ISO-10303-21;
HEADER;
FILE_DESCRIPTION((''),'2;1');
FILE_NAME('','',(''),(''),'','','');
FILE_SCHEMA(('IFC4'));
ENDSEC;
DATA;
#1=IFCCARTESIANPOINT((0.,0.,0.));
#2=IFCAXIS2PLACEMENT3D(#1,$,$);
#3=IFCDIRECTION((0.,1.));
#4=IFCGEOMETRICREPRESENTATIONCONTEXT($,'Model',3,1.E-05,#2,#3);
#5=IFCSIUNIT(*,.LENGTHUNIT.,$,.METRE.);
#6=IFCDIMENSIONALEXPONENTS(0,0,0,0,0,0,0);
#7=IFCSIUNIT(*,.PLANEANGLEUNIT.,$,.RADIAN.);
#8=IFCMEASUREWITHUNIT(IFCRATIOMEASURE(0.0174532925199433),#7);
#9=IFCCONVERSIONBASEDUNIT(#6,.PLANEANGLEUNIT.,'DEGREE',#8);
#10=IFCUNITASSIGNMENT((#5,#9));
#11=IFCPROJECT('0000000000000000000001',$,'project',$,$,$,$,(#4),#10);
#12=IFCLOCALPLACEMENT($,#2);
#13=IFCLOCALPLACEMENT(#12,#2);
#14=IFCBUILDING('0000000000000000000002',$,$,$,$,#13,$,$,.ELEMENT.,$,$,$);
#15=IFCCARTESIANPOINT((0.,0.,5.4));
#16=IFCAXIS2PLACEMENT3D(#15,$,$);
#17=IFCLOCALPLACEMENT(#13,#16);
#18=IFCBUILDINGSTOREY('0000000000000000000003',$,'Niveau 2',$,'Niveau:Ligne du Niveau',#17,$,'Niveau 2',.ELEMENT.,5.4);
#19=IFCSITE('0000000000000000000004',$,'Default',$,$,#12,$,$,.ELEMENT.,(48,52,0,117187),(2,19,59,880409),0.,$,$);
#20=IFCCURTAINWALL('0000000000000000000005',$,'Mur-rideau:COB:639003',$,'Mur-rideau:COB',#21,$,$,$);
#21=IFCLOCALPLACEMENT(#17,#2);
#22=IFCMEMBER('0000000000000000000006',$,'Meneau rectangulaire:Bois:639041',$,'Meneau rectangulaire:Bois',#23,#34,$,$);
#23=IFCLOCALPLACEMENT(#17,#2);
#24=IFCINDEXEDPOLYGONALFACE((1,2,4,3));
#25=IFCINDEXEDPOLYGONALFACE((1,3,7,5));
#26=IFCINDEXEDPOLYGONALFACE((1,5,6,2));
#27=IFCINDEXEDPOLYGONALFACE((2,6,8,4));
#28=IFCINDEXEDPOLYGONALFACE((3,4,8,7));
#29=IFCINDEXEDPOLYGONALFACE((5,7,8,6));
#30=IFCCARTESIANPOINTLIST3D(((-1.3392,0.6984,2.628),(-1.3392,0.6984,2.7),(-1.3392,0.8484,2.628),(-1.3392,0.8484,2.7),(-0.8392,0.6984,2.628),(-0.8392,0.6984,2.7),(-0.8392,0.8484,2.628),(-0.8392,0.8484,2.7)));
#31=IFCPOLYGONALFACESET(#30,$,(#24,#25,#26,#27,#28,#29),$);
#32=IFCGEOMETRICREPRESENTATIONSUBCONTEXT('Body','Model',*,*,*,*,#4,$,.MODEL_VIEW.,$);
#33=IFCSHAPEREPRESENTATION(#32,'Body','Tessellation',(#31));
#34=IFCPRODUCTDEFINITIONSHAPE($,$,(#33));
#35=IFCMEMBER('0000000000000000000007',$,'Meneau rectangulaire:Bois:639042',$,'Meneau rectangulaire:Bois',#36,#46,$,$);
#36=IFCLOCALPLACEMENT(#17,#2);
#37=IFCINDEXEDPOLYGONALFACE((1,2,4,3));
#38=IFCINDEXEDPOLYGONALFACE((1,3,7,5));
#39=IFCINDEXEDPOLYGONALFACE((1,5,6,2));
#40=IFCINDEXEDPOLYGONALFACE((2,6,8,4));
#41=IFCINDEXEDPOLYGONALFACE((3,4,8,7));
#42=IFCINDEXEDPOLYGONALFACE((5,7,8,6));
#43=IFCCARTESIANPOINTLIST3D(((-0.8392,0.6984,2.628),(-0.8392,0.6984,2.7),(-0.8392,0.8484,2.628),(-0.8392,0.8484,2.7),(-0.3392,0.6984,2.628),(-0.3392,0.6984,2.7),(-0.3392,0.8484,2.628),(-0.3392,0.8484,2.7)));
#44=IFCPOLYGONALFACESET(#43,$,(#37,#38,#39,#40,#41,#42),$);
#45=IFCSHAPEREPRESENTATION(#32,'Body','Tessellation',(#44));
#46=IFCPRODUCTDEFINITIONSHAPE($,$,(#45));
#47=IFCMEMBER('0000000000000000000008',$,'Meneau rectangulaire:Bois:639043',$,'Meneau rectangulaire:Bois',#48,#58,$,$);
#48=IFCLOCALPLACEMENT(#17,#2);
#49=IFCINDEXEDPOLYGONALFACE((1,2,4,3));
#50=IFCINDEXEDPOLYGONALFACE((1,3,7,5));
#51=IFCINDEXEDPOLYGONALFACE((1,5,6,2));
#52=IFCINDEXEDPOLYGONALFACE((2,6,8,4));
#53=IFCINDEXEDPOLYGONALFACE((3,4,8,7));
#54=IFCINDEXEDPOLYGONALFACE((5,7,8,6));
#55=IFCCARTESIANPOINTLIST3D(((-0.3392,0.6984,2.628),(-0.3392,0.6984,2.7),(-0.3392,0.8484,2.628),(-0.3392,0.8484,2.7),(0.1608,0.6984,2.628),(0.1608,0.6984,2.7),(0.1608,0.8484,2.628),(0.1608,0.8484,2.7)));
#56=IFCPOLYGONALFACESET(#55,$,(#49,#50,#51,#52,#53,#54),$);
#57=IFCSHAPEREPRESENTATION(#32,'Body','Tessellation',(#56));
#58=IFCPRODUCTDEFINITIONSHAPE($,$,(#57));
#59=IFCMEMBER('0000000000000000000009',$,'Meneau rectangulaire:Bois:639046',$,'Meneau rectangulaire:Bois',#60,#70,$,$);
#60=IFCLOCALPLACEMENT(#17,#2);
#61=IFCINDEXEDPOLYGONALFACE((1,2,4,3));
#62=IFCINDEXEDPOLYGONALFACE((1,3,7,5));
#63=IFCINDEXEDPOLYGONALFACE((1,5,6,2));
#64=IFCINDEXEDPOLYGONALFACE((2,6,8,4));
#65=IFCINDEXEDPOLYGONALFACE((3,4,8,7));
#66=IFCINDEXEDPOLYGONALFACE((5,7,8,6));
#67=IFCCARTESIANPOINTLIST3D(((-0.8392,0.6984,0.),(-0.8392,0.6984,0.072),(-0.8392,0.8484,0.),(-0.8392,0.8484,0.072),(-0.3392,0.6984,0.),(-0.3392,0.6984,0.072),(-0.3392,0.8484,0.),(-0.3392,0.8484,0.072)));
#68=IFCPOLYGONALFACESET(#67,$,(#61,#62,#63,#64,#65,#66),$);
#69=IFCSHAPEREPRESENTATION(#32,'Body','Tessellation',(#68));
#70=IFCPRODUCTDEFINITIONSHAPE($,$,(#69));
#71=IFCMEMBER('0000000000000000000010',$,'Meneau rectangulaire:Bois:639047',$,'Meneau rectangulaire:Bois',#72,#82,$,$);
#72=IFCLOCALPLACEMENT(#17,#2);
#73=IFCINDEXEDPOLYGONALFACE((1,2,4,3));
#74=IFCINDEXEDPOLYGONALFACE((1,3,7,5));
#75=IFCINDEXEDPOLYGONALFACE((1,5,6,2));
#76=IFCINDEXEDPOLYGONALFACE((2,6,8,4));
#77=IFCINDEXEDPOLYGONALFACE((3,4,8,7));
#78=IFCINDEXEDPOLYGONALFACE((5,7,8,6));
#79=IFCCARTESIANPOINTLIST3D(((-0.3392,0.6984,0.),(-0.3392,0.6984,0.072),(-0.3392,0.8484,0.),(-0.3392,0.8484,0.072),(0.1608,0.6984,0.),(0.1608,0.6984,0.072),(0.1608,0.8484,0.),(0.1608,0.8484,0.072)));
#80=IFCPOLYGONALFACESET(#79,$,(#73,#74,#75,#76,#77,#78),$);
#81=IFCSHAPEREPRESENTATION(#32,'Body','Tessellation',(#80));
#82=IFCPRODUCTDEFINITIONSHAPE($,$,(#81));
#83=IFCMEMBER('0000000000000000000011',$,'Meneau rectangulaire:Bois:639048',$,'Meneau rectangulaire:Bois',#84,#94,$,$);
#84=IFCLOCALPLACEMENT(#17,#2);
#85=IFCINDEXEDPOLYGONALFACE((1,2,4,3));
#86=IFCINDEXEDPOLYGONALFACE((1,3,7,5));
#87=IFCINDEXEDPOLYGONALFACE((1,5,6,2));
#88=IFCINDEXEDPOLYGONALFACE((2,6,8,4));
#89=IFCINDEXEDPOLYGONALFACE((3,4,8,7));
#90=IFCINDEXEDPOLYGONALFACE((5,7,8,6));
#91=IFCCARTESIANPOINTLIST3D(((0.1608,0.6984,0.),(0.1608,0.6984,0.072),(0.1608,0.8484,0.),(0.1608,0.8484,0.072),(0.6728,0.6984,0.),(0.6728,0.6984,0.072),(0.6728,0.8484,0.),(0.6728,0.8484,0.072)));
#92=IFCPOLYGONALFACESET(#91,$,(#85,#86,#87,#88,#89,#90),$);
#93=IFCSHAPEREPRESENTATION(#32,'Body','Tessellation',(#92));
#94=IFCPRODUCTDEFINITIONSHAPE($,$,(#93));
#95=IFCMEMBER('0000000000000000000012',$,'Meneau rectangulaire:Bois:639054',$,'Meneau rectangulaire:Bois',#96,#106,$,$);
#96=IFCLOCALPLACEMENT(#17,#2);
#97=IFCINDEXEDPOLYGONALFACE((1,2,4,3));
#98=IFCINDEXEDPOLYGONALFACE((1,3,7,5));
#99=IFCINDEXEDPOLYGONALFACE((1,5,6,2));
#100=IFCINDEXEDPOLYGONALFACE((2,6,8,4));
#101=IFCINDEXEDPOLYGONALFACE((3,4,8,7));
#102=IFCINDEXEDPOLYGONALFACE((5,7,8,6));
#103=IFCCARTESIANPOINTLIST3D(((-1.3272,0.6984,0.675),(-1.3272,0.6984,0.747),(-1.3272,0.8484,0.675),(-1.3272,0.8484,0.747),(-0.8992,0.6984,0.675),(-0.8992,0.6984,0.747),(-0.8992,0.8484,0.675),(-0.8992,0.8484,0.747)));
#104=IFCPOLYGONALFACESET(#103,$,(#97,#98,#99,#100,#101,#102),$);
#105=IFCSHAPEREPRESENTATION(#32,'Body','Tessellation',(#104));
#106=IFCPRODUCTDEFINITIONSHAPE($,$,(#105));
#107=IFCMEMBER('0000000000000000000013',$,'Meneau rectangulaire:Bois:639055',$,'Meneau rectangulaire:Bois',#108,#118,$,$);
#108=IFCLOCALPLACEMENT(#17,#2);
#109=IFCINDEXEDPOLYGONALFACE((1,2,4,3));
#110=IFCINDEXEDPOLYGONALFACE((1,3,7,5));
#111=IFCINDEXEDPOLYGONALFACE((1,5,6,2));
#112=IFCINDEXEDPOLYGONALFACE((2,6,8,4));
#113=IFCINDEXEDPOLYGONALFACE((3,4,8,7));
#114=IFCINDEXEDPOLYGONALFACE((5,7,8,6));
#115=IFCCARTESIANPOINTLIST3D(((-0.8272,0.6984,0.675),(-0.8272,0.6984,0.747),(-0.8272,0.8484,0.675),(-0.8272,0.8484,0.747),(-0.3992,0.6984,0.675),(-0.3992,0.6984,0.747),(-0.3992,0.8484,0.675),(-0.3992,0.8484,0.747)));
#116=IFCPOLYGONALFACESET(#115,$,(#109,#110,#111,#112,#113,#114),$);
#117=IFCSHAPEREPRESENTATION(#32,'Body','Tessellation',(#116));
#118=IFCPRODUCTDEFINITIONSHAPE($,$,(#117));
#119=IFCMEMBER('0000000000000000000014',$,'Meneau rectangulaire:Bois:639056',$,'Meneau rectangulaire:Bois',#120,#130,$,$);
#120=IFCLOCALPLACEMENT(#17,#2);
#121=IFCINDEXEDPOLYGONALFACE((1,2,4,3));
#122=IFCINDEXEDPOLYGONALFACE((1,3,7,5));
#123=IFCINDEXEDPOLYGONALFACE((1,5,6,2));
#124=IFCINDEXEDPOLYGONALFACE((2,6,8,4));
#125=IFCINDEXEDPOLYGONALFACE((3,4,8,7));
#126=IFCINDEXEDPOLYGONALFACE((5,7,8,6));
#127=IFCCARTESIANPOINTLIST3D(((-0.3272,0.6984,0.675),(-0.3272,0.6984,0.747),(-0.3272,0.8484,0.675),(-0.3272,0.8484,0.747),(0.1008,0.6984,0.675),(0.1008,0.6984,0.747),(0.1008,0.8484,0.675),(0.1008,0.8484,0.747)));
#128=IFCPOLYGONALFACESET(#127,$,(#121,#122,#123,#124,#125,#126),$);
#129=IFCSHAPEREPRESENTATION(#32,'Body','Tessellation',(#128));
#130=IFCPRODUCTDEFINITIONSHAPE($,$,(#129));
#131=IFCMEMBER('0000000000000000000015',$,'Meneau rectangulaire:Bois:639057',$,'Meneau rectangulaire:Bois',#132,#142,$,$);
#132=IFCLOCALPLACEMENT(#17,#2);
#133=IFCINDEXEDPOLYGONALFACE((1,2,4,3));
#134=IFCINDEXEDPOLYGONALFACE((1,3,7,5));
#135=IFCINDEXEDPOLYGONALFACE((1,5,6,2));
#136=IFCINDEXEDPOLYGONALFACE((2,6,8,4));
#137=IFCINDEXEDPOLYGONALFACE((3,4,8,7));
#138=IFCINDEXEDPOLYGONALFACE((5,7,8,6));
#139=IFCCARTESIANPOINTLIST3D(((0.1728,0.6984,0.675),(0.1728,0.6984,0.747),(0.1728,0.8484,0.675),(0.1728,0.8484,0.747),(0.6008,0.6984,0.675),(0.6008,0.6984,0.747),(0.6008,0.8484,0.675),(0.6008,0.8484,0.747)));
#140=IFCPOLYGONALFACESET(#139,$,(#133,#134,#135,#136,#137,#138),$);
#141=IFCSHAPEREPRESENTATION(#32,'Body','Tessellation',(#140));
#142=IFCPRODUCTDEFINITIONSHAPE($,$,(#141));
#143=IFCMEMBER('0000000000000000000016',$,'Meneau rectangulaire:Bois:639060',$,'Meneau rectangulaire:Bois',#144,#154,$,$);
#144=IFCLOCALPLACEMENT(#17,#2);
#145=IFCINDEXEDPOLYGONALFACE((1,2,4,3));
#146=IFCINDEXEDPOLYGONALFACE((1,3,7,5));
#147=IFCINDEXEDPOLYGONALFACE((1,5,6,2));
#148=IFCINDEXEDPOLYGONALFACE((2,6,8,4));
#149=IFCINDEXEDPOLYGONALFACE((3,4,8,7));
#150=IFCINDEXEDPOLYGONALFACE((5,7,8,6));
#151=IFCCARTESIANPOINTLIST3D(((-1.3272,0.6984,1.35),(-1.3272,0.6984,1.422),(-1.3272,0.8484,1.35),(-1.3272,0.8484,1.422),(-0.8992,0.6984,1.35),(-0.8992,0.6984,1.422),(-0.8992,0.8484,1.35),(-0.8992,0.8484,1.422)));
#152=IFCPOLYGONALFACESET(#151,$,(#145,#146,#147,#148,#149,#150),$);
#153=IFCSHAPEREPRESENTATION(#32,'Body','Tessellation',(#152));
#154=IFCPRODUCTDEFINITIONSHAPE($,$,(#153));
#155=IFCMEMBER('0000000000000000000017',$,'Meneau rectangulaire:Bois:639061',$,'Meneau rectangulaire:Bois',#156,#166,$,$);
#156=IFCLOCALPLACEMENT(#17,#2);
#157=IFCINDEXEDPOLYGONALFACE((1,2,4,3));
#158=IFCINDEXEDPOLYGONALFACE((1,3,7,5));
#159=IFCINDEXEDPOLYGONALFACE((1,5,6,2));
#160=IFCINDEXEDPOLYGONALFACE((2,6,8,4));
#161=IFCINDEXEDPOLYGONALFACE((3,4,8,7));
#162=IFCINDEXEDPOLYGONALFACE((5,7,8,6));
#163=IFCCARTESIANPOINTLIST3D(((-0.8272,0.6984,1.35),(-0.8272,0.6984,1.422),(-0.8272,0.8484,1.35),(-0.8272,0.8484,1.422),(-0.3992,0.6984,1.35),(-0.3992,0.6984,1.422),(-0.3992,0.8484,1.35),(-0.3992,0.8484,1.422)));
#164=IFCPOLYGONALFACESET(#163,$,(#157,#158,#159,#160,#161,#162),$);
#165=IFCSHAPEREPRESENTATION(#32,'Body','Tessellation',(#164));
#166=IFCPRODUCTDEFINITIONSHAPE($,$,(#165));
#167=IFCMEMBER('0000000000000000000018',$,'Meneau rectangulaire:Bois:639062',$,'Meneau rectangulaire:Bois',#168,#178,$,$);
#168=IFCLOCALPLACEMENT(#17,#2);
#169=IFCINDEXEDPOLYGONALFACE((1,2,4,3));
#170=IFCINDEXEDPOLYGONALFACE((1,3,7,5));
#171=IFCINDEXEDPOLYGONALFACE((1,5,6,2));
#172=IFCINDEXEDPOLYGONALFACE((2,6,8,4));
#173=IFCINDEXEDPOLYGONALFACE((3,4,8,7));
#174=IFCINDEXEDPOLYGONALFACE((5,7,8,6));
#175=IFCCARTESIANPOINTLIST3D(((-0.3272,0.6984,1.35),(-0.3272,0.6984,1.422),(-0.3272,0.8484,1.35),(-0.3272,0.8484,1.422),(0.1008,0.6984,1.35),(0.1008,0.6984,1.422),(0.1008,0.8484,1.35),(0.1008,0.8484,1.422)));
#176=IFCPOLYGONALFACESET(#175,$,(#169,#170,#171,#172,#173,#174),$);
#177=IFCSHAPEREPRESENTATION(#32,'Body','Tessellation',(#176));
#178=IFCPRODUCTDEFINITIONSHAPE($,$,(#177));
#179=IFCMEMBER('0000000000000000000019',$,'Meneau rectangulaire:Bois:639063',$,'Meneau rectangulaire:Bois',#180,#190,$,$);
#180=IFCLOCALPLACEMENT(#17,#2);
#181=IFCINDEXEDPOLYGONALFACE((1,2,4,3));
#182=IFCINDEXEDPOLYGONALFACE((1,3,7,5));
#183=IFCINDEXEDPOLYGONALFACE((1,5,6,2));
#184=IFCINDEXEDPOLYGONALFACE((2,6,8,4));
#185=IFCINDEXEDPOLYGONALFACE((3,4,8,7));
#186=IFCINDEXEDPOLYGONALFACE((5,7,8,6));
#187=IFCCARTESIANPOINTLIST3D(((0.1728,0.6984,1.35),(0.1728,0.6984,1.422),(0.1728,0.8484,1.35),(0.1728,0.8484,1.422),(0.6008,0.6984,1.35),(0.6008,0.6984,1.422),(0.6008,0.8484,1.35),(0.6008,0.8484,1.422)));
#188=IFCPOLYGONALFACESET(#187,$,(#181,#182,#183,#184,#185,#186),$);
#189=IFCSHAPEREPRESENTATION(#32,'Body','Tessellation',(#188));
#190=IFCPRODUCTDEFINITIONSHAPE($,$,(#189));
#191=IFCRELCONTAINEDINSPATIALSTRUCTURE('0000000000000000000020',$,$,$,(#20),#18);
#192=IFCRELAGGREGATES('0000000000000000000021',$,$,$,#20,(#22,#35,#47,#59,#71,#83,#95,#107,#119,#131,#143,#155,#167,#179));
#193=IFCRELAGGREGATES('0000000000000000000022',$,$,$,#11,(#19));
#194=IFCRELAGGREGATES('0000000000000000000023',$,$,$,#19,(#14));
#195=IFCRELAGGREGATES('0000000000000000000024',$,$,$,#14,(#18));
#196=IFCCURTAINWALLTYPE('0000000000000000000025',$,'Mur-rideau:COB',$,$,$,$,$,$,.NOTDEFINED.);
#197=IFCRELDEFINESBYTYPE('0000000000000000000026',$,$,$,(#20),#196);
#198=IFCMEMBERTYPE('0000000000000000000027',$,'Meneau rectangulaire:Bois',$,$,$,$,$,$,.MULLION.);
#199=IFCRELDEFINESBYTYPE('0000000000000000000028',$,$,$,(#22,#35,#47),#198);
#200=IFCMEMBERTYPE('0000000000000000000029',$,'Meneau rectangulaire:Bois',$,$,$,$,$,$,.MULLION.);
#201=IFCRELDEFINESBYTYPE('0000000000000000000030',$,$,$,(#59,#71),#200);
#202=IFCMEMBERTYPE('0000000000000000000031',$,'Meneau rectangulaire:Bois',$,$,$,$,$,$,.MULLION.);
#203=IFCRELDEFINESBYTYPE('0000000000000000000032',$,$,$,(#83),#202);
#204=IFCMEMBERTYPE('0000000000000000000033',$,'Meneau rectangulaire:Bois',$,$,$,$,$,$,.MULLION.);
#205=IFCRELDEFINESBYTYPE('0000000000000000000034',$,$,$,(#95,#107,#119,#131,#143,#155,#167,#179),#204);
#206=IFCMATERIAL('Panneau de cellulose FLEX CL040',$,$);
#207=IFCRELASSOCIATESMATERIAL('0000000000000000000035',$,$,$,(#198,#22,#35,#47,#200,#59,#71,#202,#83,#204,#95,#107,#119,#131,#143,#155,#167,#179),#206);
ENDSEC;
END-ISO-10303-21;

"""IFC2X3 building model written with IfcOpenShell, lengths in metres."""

from ifc_helpers import new_model, entity, si_unit, converted_unit, direction, frame, origin, origin_2d_with_axis, place, context, subcontext, project, spatial, rectangle, extrude, source, transform, mapped, material, type_object, type_shapes, element, aggregate, save


model = new_model("IFC2X3")

# Units and contexts
model_context = context("Model", 3, precision=1e-05, world=origin(), true_north=direction((0.0, 1.0)))
body_context = subcontext(model_context, "Body", "Model", "MODEL_VIEW")
ifc_project = project(units=[si_unit("LENGTHUNIT", "METRE"), converted_unit("PLANEANGLEUNIT", "DEGREE", entity("IfcRatioMeasure", 0.0174532925199433), si_unit("PLANEANGLEUNIT", "RADIAN"), dimensions=[0, 0, 0, 0, 0, 0, 0])], contexts=[model_context])

# Site, building, storey
site_placement = place(None, origin())
site = spatial("IfcSite", under=ifc_project, at=site_placement, Name="Default", CompositionType="ELEMENT", RefLatitude=(48, 52, 0, 117187), RefLongitude=(2, 19, 59, 880409), RefElevation=0.0)
building_placement = place(site_placement, origin())
building = spatial("IfcBuilding", under=site, at=building_placement, CompositionType="ELEMENT")
storey_placement = place(building_placement, frame((0.0, 0.0, 5.4)))
storey = spatial("IfcBuildingStorey", under=building, at=storey_placement, Name="Niveau 2", ObjectType="Niveau:Ligne du Niveau", LongName="Niveau 2", CompositionType="ELEMENT", Elevation=5.4)

# Curtain wall, members
curtain_wall_type_1 = type_object("IfcCurtainWallType", Name="Mur-rideau:COB", PredefinedType="NOTDEFINED")
curtain_wall_1_placement = place(storey_placement, frame((0.0, 0.0, -5.4)))
curtain_wall_1 = element("IfcCurtainWall", 1, at=curtain_wall_1_placement, inside=storey, type_object=curtain_wall_type_1, Name="Mur-rideau:COB:639003", ObjectType="Mur-rideau:COB")
ifc_material_1 = material(Name="Panneau de cellulose FLEX CL040")
member_type_1 = type_object("IfcMemberType", Name="Meneau rectangulaire:Bois", PredefinedType="MULLION", material=ifc_material_1)
shared_shape_1 = source(origin(), body_context, "Body", "SweptSolid", [
    extrude(rectangle(XDim=0.15, YDim=0.072, at=origin_2d_with_axis()), frame((-0.036, 0.0, -0.5), z_axis=(0.0, 0.0, 1.0), x_axis=(0.0, -1.0, 0.0)), (0.0, 0.0, 1.0), 0.5),
])
type_shapes(member_type_1, [shared_shape_1])
member_1_placement = place(storey_placement, frame((-0.8392, 0.7734, 2.7), z_axis=(1.0, 0.0, 0.0), x_axis=(0.0, 0.0, 1.0)))
member_1 = element("IfcMember", 2, at=member_1_placement, type_object=member_type_1, material=ifc_material_1, Name="Meneau rectangulaire:Bois:639041", ObjectType="Meneau rectangulaire:Bois", context=body_context, shape_type="MappedRepresentation", body=[
    mapped(shared_shape_1, transform((0.0, 0.0, 0.0), scale=1.0)),
])
member_2_placement = place(storey_placement, frame((-0.3392, 0.7734, 2.7), z_axis=(1.0, 0.0, 0.0), x_axis=(0.0, 0.0, 1.0)))
member_2 = element("IfcMember", 3, at=member_2_placement, type_object=member_type_1, material=ifc_material_1, Name="Meneau rectangulaire:Bois:639042", ObjectType="Meneau rectangulaire:Bois", context=body_context, shape_type="MappedRepresentation", body=[
    mapped(shared_shape_1, transform((0.0, 0.0, 0.0), scale=1.0)),
])
member_3_placement = place(storey_placement, frame((0.1608, 0.7734, 2.7), z_axis=(1.0, 0.0, 0.0), x_axis=(0.0, 0.0, 1.0)))
member_3 = element("IfcMember", 4, at=member_3_placement, type_object=member_type_1, material=ifc_material_1, Name="Meneau rectangulaire:Bois:639043", ObjectType="Meneau rectangulaire:Bois", context=body_context, shape_type="MappedRepresentation", body=[
    mapped(shared_shape_1, transform((0.0, 0.0, 0.0), scale=1.0)),
])
member_type_2 = type_object("IfcMemberType", Name="Meneau rectangulaire:Bois", PredefinedType="MULLION", material=ifc_material_1)
shared_shape_2 = source(origin(), body_context, "Body", "SweptSolid", [
    extrude(rectangle(XDim=0.15, YDim=0.072, at=origin_2d_with_axis()), frame((-0.036, 0.0, -0.5), z_axis=(0.0, 0.0, 1.0), x_axis=(0.0, -1.0, 0.0)), (0.0, 0.0, 1.0), 0.5),
])
type_shapes(member_type_2, [shared_shape_2])
member_4_placement = place(storey_placement, frame((-0.8392, 0.7734, 0.0), z_axis=(-1.0, 0.0, 0.0), x_axis=(0.0, 0.0, -1.0)))
member_4 = element("IfcMember", 5, at=member_4_placement, type_object=member_type_2, material=ifc_material_1, Name="Meneau rectangulaire:Bois:639046", ObjectType="Meneau rectangulaire:Bois", context=body_context, shape_type="MappedRepresentation", body=[
    mapped(shared_shape_2, transform((0.0, 0.0, 0.0), scale=1.0)),
])
member_5_placement = place(storey_placement, frame((-0.3392, 0.7734, 0.0), z_axis=(-1.0, 0.0, 0.0), x_axis=(0.0, 0.0, -1.0)))
member_5 = element("IfcMember", 6, at=member_5_placement, type_object=member_type_2, material=ifc_material_1, Name="Meneau rectangulaire:Bois:639047", ObjectType="Meneau rectangulaire:Bois", context=body_context, shape_type="MappedRepresentation", body=[
    mapped(shared_shape_2, transform((0.0, 0.0, 0.0), scale=1.0)),
])
member_type_3 = type_object("IfcMemberType", Name="Meneau rectangulaire:Bois", PredefinedType="MULLION", material=ifc_material_1)
shared_shape_3 = source(origin(), body_context, "Body", "SweptSolid", [
    extrude(rectangle(XDim=0.15, YDim=0.072, at=origin_2d_with_axis()), frame((-0.036, 0.0, -0.512), z_axis=(0.0, 0.0, 1.0), x_axis=(0.0, -1.0, 0.0)), (0.0, 0.0, 1.0), 0.512),
])
type_shapes(member_type_3, [shared_shape_3])
member_6_placement = place(storey_placement, frame((0.1608, 0.7734, 0.0), z_axis=(-1.0, 0.0, 0.0), x_axis=(0.0, 0.0, -1.0)))
member_6 = element("IfcMember", 7, at=member_6_placement, type_object=member_type_3, material=ifc_material_1, Name="Meneau rectangulaire:Bois:639048", ObjectType="Meneau rectangulaire:Bois", context=body_context, shape_type="MappedRepresentation", body=[
    mapped(shared_shape_3, transform((0.0, 0.0, 0.0), scale=1.0)),
])
member_type_4 = type_object("IfcMemberType", Name="Meneau rectangulaire:Bois", PredefinedType="MULLION", material=ifc_material_1)
shared_shape_4 = source(origin(), body_context, "Body", "SweptSolid", [
    extrude(rectangle(XDim=0.15, YDim=0.072, at=origin_2d_with_axis()), frame((-0.024, 0.0, -0.428), z_axis=(0.0, 0.0, 1.0), x_axis=(0.0, -1.0, 0.0)), (0.0, 0.0, 1.0), 0.428),
])
type_shapes(member_type_4, [shared_shape_4])
member_7_placement = place(storey_placement, frame((-0.8992, 0.7734, 0.735), z_axis=(1.0, 0.0, 0.0), x_axis=(0.0, 0.0, 1.0)))
member_7 = element("IfcMember", 8, at=member_7_placement, type_object=member_type_4, material=ifc_material_1, Name="Meneau rectangulaire:Bois:639054", ObjectType="Meneau rectangulaire:Bois", context=body_context, shape_type="MappedRepresentation", body=[
    mapped(shared_shape_4, transform((0.0, 0.0, 0.0), scale=1.0)),
])
member_8_placement = place(storey_placement, frame((-0.3992, 0.7734, 0.735), z_axis=(1.0, 0.0, 0.0), x_axis=(0.0, 0.0, 1.0)))
member_8 = element("IfcMember", 9, at=member_8_placement, type_object=member_type_4, material=ifc_material_1, Name="Meneau rectangulaire:Bois:639055", ObjectType="Meneau rectangulaire:Bois", context=body_context, shape_type="MappedRepresentation", body=[
    mapped(shared_shape_4, transform((0.0, 0.0, 0.0), scale=1.0)),
])
member_9_placement = place(storey_placement, frame((0.1008, 0.7734, 0.735), z_axis=(1.0, 0.0, 0.0), x_axis=(0.0, 0.0, 1.0)))
member_9 = element("IfcMember", 10, at=member_9_placement, type_object=member_type_4, material=ifc_material_1, Name="Meneau rectangulaire:Bois:639056", ObjectType="Meneau rectangulaire:Bois", context=body_context, shape_type="MappedRepresentation", body=[
    mapped(shared_shape_4, transform((0.0, 0.0, 0.0), scale=1.0)),
])
member_10_placement = place(storey_placement, frame((0.6008, 0.7734, 0.735), z_axis=(1.0, 0.0, 0.0), x_axis=(0.0, 0.0, 1.0)))
member_10 = element("IfcMember", 11, at=member_10_placement, type_object=member_type_4, material=ifc_material_1, Name="Meneau rectangulaire:Bois:639057", ObjectType="Meneau rectangulaire:Bois", context=body_context, shape_type="MappedRepresentation", body=[
    mapped(shared_shape_4, transform((0.0, 0.0, 0.0), scale=1.0)),
])
member_11_placement = place(storey_placement, frame((-0.8992, 0.7734, 1.41), z_axis=(1.0, 0.0, 0.0), x_axis=(0.0, 0.0, 1.0)))
member_11 = element("IfcMember", 12, at=member_11_placement, type_object=member_type_4, material=ifc_material_1, Name="Meneau rectangulaire:Bois:639060", ObjectType="Meneau rectangulaire:Bois", context=body_context, shape_type="MappedRepresentation", body=[
    mapped(shared_shape_4, transform((0.0, 0.0, 0.0), scale=1.0)),
])
member_12_placement = place(storey_placement, frame((-0.3992, 0.7734, 1.41), z_axis=(1.0, 0.0, 0.0), x_axis=(0.0, 0.0, 1.0)))
member_12 = element("IfcMember", 13, at=member_12_placement, type_object=member_type_4, material=ifc_material_1, Name="Meneau rectangulaire:Bois:639061", ObjectType="Meneau rectangulaire:Bois", context=body_context, shape_type="MappedRepresentation", body=[
    mapped(shared_shape_4, transform((0.0, 0.0, 0.0), scale=1.0)),
])
member_13_placement = place(storey_placement, frame((0.1008, 0.7734, 1.41), z_axis=(1.0, 0.0, 0.0), x_axis=(0.0, 0.0, 1.0)))
member_13 = element("IfcMember", 14, at=member_13_placement, type_object=member_type_4, material=ifc_material_1, Name="Meneau rectangulaire:Bois:639062", ObjectType="Meneau rectangulaire:Bois", context=body_context, shape_type="MappedRepresentation", body=[
    mapped(shared_shape_4, transform((0.0, 0.0, 0.0), scale=1.0)),
])
member_14_placement = place(storey_placement, frame((0.6008, 0.7734, 1.41), z_axis=(1.0, 0.0, 0.0), x_axis=(0.0, 0.0, 1.0)))
member_14 = element("IfcMember", 15, at=member_14_placement, type_object=member_type_4, material=ifc_material_1, Name="Meneau rectangulaire:Bois:639063", ObjectType="Meneau rectangulaire:Bois", context=body_context, shape_type="MappedRepresentation", body=[
    mapped(shared_shape_4, transform((0.0, 0.0, 0.0), scale=1.0)),
])
aggregate(curtain_wall_1, [member_1, member_2, member_3, member_4, member_5, member_6, member_7, member_8, member_9, member_10, member_11, member_12, member_13, member_14])

save(model, "model.ifc")
